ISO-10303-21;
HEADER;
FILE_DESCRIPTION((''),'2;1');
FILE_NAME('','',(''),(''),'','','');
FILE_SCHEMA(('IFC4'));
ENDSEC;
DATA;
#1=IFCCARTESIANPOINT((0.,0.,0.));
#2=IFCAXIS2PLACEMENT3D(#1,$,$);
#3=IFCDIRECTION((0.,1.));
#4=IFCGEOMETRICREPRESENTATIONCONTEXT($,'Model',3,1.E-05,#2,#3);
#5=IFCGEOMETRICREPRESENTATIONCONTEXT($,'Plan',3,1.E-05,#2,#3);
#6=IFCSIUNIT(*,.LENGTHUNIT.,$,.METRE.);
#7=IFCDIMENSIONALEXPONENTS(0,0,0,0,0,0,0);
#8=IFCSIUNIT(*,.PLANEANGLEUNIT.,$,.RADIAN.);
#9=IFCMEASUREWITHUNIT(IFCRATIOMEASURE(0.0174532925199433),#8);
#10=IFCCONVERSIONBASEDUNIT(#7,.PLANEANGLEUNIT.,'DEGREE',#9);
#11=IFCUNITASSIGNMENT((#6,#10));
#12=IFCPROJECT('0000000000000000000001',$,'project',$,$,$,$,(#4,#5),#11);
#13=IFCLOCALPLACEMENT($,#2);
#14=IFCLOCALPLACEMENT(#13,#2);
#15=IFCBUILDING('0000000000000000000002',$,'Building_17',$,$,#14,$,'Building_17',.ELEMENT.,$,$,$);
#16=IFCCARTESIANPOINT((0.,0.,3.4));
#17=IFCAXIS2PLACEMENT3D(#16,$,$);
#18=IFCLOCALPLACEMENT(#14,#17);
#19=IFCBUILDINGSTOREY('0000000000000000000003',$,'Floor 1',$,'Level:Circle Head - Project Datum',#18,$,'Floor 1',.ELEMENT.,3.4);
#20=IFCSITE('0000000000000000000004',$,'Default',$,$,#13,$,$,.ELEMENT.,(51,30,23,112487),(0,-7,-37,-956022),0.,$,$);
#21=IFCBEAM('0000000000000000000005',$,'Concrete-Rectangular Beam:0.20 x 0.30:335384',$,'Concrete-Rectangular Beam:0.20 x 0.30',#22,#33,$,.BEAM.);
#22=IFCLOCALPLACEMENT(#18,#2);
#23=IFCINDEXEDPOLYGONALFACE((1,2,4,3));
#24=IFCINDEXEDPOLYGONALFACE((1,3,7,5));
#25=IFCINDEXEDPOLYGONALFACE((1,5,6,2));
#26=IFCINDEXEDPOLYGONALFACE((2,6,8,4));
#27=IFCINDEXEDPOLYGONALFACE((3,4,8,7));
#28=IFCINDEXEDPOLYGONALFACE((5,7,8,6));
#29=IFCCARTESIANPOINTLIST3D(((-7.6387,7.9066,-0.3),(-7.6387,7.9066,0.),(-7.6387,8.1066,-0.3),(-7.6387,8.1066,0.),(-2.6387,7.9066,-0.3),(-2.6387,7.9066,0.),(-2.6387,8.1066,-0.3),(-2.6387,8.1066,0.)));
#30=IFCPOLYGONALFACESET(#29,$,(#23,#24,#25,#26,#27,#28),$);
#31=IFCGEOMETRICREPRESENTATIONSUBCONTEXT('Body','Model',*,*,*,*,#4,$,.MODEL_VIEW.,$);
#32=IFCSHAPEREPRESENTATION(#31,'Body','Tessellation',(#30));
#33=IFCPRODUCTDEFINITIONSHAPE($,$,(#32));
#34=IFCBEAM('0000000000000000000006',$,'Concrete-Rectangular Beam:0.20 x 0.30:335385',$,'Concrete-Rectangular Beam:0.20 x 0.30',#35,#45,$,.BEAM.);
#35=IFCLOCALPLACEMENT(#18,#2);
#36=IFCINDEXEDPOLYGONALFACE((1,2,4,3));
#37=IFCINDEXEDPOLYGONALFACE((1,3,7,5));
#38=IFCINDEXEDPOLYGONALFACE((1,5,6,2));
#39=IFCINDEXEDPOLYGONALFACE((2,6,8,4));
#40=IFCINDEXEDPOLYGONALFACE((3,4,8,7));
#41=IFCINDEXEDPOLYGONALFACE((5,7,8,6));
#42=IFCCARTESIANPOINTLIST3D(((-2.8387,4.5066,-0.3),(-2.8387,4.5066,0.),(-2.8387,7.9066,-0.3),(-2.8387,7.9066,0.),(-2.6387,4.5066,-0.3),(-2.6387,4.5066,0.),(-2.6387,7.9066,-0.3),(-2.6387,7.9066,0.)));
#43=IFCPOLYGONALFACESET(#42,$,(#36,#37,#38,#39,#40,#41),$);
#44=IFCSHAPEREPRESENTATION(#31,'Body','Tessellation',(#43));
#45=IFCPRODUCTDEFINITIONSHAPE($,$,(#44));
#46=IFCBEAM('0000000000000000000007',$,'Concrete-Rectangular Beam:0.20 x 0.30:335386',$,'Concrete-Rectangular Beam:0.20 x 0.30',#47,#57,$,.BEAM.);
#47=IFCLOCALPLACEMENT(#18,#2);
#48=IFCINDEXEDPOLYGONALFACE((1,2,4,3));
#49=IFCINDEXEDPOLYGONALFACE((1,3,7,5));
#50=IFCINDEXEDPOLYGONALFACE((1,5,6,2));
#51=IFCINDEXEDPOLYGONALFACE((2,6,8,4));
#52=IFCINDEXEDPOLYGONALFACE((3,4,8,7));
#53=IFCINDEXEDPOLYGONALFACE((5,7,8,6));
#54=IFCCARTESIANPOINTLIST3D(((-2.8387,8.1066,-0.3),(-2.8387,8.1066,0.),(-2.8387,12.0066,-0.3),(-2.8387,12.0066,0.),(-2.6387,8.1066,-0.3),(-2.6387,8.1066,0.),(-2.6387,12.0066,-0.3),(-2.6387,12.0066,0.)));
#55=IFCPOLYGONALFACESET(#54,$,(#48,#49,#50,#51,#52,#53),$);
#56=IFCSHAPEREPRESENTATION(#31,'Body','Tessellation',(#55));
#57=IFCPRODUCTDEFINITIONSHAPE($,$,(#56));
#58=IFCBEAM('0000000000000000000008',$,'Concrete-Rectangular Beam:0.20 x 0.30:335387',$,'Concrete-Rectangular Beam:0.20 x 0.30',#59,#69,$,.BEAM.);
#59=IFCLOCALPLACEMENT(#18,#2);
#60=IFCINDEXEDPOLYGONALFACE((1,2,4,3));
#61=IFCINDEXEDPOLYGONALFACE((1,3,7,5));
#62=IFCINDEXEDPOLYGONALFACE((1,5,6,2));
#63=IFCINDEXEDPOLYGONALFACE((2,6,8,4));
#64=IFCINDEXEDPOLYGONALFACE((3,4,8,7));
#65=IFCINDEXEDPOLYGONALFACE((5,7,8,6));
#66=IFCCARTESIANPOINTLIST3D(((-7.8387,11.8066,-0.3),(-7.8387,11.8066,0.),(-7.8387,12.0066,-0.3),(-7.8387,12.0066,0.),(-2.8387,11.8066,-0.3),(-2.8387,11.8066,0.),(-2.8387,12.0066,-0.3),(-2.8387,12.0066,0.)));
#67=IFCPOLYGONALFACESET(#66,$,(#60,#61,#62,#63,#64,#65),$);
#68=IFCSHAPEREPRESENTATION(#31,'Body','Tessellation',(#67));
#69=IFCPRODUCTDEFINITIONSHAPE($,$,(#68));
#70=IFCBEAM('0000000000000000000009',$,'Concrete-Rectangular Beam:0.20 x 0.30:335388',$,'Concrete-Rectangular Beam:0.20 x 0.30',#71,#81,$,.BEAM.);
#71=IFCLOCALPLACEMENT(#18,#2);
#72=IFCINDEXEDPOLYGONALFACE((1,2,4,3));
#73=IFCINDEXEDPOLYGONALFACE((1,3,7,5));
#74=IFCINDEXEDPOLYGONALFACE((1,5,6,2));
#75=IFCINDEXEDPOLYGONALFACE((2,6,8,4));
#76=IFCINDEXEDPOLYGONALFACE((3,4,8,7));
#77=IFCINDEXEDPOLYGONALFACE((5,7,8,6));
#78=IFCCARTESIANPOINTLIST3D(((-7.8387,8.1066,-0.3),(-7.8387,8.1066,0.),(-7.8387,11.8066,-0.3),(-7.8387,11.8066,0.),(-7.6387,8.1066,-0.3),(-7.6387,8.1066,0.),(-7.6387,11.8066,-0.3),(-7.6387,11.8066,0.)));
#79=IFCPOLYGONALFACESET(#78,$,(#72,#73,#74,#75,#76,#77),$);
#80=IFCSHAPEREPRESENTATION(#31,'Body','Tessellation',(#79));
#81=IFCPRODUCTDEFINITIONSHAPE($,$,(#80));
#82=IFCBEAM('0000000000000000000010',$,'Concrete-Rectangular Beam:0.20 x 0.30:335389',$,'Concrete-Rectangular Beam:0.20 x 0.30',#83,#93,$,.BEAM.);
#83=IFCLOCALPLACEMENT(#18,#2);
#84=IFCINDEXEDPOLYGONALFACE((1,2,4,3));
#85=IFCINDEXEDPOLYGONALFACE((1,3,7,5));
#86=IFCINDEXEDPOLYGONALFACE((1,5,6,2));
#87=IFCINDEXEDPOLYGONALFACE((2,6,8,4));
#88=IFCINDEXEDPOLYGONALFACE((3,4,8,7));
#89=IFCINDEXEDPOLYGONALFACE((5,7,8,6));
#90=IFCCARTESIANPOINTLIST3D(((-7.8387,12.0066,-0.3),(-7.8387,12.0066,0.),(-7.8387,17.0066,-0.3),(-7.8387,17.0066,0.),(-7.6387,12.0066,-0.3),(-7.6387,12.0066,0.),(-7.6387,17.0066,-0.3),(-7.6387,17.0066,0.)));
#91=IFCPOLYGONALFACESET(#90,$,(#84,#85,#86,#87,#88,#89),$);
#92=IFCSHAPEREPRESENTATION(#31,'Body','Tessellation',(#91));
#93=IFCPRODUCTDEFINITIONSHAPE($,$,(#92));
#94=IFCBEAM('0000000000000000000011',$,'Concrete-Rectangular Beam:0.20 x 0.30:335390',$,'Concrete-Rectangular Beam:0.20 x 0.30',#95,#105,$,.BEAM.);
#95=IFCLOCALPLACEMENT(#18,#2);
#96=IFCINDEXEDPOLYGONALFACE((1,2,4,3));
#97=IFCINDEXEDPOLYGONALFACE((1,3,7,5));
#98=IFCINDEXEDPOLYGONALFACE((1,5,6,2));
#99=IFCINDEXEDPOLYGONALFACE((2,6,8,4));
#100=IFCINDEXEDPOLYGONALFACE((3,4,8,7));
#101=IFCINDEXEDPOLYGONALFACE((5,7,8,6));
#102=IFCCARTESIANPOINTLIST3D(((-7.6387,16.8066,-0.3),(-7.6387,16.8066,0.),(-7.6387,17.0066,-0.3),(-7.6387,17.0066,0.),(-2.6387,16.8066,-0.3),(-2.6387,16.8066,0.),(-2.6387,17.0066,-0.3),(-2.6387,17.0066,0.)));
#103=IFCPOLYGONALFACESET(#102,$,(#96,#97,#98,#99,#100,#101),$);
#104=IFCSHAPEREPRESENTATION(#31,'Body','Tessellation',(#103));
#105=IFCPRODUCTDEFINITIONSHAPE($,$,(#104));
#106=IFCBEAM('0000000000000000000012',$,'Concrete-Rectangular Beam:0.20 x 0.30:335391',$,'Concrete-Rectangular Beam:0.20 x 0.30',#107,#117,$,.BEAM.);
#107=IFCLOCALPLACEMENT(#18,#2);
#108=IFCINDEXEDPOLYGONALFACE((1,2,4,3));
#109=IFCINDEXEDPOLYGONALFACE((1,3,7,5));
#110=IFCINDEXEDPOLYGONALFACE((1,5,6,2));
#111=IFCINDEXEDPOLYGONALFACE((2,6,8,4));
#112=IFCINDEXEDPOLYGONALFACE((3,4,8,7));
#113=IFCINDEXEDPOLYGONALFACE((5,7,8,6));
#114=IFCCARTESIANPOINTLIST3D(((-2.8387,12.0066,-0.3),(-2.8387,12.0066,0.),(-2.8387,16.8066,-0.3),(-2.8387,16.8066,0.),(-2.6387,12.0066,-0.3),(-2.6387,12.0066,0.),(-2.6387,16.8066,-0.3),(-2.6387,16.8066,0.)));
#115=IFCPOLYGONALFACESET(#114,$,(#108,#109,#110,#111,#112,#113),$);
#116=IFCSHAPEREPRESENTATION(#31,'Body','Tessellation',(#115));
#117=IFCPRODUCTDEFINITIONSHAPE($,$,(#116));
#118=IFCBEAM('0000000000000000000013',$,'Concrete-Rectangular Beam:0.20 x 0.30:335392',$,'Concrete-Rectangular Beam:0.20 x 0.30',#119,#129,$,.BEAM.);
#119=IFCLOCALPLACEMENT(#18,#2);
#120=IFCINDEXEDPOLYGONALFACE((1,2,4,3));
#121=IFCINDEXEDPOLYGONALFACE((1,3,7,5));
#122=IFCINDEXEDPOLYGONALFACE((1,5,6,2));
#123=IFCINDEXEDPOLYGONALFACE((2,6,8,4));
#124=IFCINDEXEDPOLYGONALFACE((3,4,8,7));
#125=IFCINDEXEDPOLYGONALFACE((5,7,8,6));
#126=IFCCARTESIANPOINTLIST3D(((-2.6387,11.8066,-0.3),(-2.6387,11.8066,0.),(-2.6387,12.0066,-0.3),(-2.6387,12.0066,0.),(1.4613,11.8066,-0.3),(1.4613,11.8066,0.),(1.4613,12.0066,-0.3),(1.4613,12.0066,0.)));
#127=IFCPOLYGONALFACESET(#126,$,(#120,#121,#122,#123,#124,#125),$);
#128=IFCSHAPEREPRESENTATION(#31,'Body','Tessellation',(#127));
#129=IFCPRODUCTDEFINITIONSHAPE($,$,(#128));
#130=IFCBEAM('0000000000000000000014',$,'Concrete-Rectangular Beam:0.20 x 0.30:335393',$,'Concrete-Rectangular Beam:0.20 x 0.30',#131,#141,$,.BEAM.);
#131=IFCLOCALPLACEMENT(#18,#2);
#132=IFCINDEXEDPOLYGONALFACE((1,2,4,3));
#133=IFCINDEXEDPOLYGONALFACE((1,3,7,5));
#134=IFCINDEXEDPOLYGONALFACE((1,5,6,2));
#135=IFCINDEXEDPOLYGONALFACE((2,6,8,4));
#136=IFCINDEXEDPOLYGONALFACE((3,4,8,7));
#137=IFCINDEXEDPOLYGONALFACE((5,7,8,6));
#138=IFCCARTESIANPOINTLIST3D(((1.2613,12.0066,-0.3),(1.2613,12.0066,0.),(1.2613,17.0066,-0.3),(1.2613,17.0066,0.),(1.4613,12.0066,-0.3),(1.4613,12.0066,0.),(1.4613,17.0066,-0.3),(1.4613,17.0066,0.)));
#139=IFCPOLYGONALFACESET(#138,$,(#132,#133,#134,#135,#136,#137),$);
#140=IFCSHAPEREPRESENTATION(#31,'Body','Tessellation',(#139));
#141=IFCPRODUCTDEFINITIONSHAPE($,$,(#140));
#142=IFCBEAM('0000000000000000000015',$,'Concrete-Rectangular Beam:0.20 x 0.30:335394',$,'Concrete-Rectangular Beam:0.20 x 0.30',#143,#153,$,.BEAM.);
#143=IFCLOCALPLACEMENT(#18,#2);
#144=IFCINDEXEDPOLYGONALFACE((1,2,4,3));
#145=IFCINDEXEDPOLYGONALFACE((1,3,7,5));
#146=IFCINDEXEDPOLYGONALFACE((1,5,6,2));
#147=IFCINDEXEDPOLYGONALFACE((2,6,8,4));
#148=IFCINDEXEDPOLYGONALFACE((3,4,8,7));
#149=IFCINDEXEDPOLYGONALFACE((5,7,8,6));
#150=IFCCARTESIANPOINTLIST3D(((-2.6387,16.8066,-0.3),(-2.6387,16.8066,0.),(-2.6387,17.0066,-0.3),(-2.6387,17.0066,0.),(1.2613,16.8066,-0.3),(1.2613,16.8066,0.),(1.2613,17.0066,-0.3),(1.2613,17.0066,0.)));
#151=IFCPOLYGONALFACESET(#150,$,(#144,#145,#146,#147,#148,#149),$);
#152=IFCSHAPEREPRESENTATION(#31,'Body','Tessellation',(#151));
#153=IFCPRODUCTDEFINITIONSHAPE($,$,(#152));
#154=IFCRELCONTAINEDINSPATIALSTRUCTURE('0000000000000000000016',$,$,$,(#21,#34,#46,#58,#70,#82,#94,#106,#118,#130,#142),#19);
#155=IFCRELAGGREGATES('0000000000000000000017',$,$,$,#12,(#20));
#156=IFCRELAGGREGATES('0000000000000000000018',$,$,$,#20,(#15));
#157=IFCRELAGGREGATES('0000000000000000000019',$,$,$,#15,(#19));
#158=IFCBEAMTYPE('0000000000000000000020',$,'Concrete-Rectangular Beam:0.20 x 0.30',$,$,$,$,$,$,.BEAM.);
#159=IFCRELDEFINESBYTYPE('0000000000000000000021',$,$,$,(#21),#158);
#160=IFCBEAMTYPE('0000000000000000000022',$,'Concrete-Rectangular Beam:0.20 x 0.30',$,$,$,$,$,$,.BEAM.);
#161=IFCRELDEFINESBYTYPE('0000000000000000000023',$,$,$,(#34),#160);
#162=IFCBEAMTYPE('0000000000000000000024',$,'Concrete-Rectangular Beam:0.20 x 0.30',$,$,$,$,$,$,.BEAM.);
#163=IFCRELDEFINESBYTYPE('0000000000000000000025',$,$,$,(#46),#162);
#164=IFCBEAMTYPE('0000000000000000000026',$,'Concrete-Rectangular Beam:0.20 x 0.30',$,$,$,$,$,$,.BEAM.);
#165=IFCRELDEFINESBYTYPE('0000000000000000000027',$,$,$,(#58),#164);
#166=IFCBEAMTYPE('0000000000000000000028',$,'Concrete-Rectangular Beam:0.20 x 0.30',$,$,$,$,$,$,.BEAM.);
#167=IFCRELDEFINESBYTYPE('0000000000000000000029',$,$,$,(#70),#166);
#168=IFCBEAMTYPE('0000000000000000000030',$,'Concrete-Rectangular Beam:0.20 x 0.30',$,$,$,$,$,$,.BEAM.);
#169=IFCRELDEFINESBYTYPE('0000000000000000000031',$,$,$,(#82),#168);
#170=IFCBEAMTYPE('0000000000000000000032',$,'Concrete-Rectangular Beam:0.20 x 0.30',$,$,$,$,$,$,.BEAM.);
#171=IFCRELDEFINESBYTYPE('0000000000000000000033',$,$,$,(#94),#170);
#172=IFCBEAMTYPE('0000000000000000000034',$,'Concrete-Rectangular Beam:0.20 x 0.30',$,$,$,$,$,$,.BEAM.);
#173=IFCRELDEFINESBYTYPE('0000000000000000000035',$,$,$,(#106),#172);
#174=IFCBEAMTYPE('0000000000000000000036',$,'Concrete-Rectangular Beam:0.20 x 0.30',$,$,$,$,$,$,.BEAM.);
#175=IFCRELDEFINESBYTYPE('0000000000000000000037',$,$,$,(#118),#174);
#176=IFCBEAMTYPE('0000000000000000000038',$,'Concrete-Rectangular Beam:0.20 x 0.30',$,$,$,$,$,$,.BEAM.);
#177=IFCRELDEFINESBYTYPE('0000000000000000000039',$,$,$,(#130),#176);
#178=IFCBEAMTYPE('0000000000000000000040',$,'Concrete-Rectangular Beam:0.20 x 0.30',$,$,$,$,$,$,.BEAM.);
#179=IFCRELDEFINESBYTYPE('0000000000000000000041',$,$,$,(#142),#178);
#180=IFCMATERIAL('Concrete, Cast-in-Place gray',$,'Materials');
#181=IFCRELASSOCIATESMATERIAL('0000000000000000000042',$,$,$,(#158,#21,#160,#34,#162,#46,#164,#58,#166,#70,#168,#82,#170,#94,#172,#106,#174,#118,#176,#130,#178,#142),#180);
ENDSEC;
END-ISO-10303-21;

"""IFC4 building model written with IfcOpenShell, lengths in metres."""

from ifc_helpers import new_model, entity, si_unit, converted_unit, direction, frame, origin, place, context, subcontext, project, spatial, indexed_curve, outline, extrude, source, transform, mapped, material, type_object, type_shapes, element, save


model = new_model("IFC4")

# Units and contexts
model_context = context("Model", 3, precision=1e-05, world=origin(), true_north=direction((0.0, 1.0)))
plan_context = context("Plan", 3, precision=1e-05, world=origin(), true_north=direction((0.0, 1.0)))
body_context = subcontext(model_context, "Body", "Model", "MODEL_VIEW")
ifc_project = project(units=[si_unit("LENGTHUNIT", "METRE"), converted_unit("PLANEANGLEUNIT", "DEGREE", entity("IfcRatioMeasure", 0.0174532925199433), si_unit("PLANEANGLEUNIT", "RADIAN"), dimensions=[0, 0, 0, 0, 0, 0, 0])], contexts=[model_context, plan_context])

# Site, building, storey
site_placement = place(None, origin())
site = spatial("IfcSite", under=ifc_project, at=site_placement, Name="Default", CompositionType="ELEMENT", RefLatitude=(51, 30, 23, 112487), RefLongitude=(0, -7, -37, -956022), RefElevation=0.0)
building_placement = place(site_placement, origin())
building = spatial("IfcBuilding", under=site, at=building_placement, Name="Building_17", LongName="Building_17", CompositionType="ELEMENT")
storey_placement = place(building_placement, frame((0.0, 0.0, 3.4)))
storey = spatial("IfcBuildingStorey", under=building, at=storey_placement, Name="Floor 1", ObjectType="Level:Circle Head - Project Datum", LongName="Floor 1", CompositionType="ELEMENT", Elevation=3.4)

# Beams
ifc_material_1 = material(Name="Concrete, Cast-in-Place gray", Category="Materials")
beam_type_1 = type_object("IfcBeamType", Name="Concrete-Rectangular Beam:0.20 x 0.30", PredefinedType="BEAM", material=ifc_material_1)
shared_shape_1 = source(origin(), body_context, "Body", "SweptSolid", [
    extrude(outline(indexed_curve([(-0.15, -0.1), (0.15, -0.1), (0.15, 0.1), (-0.15, 0.1), (-0.15, -0.1)], self_intersect=False)), frame((-7.6387, 8.0066, 3.25), z_axis=(1.0, 0.0, 0.0), x_axis=(0.0, 0.0, -1.0)), (0.0, 0.0, 1.0), 5.0),
])
type_shapes(beam_type_1, [shared_shape_1])
beam_1_placement = place(storey_placement, frame((0.0, 0.0, -3.4)))
element("IfcBeam", 1, at=beam_1_placement, inside=storey, type_object=beam_type_1, material=ifc_material_1, Name="Concrete-Rectangular Beam:0.20 x 0.30:335384", ObjectType="Concrete-Rectangular Beam:0.20 x 0.30", PredefinedType="BEAM", context=body_context, shape_type="MappedRepresentation", body=[
    mapped(shared_shape_1, transform((0.0, 0.0, 0.0), scale=1.0)),
])
beam_type_2 = type_object("IfcBeamType", Name="Concrete-Rectangular Beam:0.20 x 0.30", PredefinedType="BEAM", material=ifc_material_1)
shared_shape_2 = source(origin(), body_context, "Body", "SweptSolid", [
    extrude(outline(indexed_curve([(-0.1, -0.15), (0.1, -0.15), (0.1, 0.15), (-0.1, 0.15), (-0.1, -0.15)], self_intersect=False)), frame((-2.7387, 7.9066, 3.25), z_axis=(0.0, -1.0, 0.0), x_axis=(-1.0, 0.0, 0.0)), (0.0, 0.0, 1.0), 3.4),
])
type_shapes(beam_type_2, [shared_shape_2])
beam_2_placement = place(storey_placement, frame((0.0, 0.0, -3.4)))
element("IfcBeam", 2, at=beam_2_placement, inside=storey, type_object=beam_type_2, material=ifc_material_1, Name="Concrete-Rectangular Beam:0.20 x 0.30:335385", ObjectType="Concrete-Rectangular Beam:0.20 x 0.30", PredefinedType="BEAM", context=body_context, shape_type="MappedRepresentation", body=[
    mapped(shared_shape_2, transform((0.0, 0.0, 0.0), scale=1.0)),
])
beam_type_3 = type_object("IfcBeamType", Name="Concrete-Rectangular Beam:0.20 x 0.30", PredefinedType="BEAM", material=ifc_material_1)
shared_shape_3 = source(origin(), body_context, "Body", "SweptSolid", [
    extrude(outline(indexed_curve([(-0.1, -0.15), (0.1, -0.15), (0.1, 0.15), (-0.1, 0.15), (-0.1, -0.15)], self_intersect=False)), frame((-2.7387, 8.1066, 3.25), z_axis=(0.0, 1.0, 0.0), x_axis=(-1.0, 0.0, 0.0)), (0.0, 0.0, 1.0), 3.9),
])
type_shapes(beam_type_3, [shared_shape_3])
beam_3_placement = place(storey_placement, frame((0.0, 0.0, -3.4)))
element("IfcBeam", 3, at=beam_3_placement, inside=storey, type_object=beam_type_3, material=ifc_material_1, Name="Concrete-Rectangular Beam:0.20 x 0.30:335386", ObjectType="Concrete-Rectangular Beam:0.20 x 0.30", PredefinedType="BEAM", context=body_context, shape_type="MappedRepresentation", body=[
    mapped(shared_shape_3, transform((0.0, 0.0, 0.0), scale=1.0)),
])
beam_type_4 = type_object("IfcBeamType", Name="Concrete-Rectangular Beam:0.20 x 0.30", PredefinedType="BEAM", material=ifc_material_1)
shared_shape_4 = source(origin(), body_context, "Body", "SweptSolid", [
    extrude(outline(indexed_curve([(-0.15, -0.1), (0.15, -0.1), (0.15, 0.1), (-0.15, 0.1), (-0.15, -0.1)], self_intersect=False)), frame((-2.8387, 11.9066, 3.25), z_axis=(-1.0, 0.0, 0.0), x_axis=(0.0, 0.0, -1.0)), (0.0, 0.0, 1.0), 5.0),
])
type_shapes(beam_type_4, [shared_shape_4])
beam_4_placement = place(storey_placement, frame((0.0, 0.0, -3.4)))
element("IfcBeam", 4, at=beam_4_placement, inside=storey, type_object=beam_type_4, material=ifc_material_1, Name="Concrete-Rectangular Beam:0.20 x 0.30:335387", ObjectType="Concrete-Rectangular Beam:0.20 x 0.30", PredefinedType="BEAM", context=body_context, shape_type="MappedRepresentation", body=[
    mapped(shared_shape_4, transform((0.0, 0.0, 0.0), scale=1.0)),
])
beam_type_5 = type_object("IfcBeamType", Name="Concrete-Rectangular Beam:0.20 x 0.30", PredefinedType="BEAM", material=ifc_material_1)
shared_shape_5 = source(origin(), body_context, "Body", "SweptSolid", [
    extrude(outline(indexed_curve([(-0.1, -0.15), (0.1, -0.15), (0.1, 0.15), (-0.1, 0.15), (-0.1, -0.15)], self_intersect=False)), frame((-7.7387, 11.8066, 3.25), z_axis=(0.0, -1.0, 0.0), x_axis=(-1.0, 0.0, 0.0)), (0.0, 0.0, 1.0), 3.7),
])
type_shapes(beam_type_5, [shared_shape_5])
beam_5_placement = place(storey_placement, frame((0.0, 0.0, -3.4)))
element("IfcBeam", 5, at=beam_5_placement, inside=storey, type_object=beam_type_5, material=ifc_material_1, Name="Concrete-Rectangular Beam:0.20 x 0.30:335388", ObjectType="Concrete-Rectangular Beam:0.20 x 0.30", PredefinedType="BEAM", context=body_context, shape_type="MappedRepresentation", body=[
    mapped(shared_shape_5, transform((0.0, 0.0, 0.0), scale=1.0)),
])
beam_type_6 = type_object("IfcBeamType", Name="Concrete-Rectangular Beam:0.20 x 0.30", PredefinedType="BEAM", material=ifc_material_1)
shared_shape_6 = source(origin(), body_context, "Body", "SweptSolid", [
    extrude(outline(indexed_curve([(-0.1, -0.15), (0.1, -0.15), (0.1, 0.15), (-0.1, 0.15), (-0.1, -0.15)], self_intersect=False)), frame((-7.7387, 17.0066, 3.25), z_axis=(0.0, -1.0, 0.0), x_axis=(-1.0, 0.0, 0.0)), (0.0, 0.0, 1.0), 5.0),
])
type_shapes(beam_type_6, [shared_shape_6])
beam_6_placement = place(storey_placement, frame((0.0, 0.0, -3.4)))
element("IfcBeam", 6, at=beam_6_placement, inside=storey, type_object=beam_type_6, material=ifc_material_1, Name="Concrete-Rectangular Beam:0.20 x 0.30:335389", ObjectType="Concrete-Rectangular Beam:0.20 x 0.30", PredefinedType="BEAM", context=body_context, shape_type="MappedRepresentation", body=[
    mapped(shared_shape_6, transform((0.0, 0.0, 0.0), scale=1.0)),
])
beam_type_7 = type_object("IfcBeamType", Name="Concrete-Rectangular Beam:0.20 x 0.30", PredefinedType="BEAM", material=ifc_material_1)
shared_shape_7 = source(origin(), body_context, "Body", "SweptSolid", [
    extrude(outline(indexed_curve([(-0.15, -0.1), (0.15, -0.1), (0.15, 0.1), (-0.15, 0.1), (-0.15, -0.1)], self_intersect=False)), frame((-7.6387, 16.9066, 3.25), z_axis=(1.0, 0.0, 0.0), x_axis=(0.0, 0.0, -1.0)), (0.0, 0.0, 1.0), 5.0),
])
type_shapes(beam_type_7, [shared_shape_7])
beam_7_placement = place(storey_placement, frame((0.0, 0.0, -3.4)))
element("IfcBeam", 7, at=beam_7_placement, inside=storey, type_object=beam_type_7, material=ifc_material_1, Name="Concrete-Rectangular Beam:0.20 x 0.30:335390", ObjectType="Concrete-Rectangular Beam:0.20 x 0.30", PredefinedType="BEAM", context=body_context, shape_type="MappedRepresentation", body=[
    mapped(shared_shape_7, transform((0.0, 0.0, 0.0), scale=1.0)),
])
beam_type_8 = type_object("IfcBeamType", Name="Concrete-Rectangular Beam:0.20 x 0.30", PredefinedType="BEAM", material=ifc_material_1)
shared_shape_8 = source(origin(), body_context, "Body", "SweptSolid", [
    extrude(outline(indexed_curve([(-0.1, -0.15), (0.1, -0.15), (0.1, 0.15), (-0.1, 0.15), (-0.1, -0.15)], self_intersect=False)), frame((-2.7387, 16.8066, 3.25), z_axis=(0.0, -1.0, 0.0), x_axis=(-1.0, 0.0, 0.0)), (0.0, 0.0, 1.0), 4.8),
])
type_shapes(beam_type_8, [shared_shape_8])
beam_8_placement = place(storey_placement, frame((0.0, 0.0, -3.4)))
element("IfcBeam", 8, at=beam_8_placement, inside=storey, type_object=beam_type_8, material=ifc_material_1, Name="Concrete-Rectangular Beam:0.20 x 0.30:335391", ObjectType="Concrete-Rectangular Beam:0.20 x 0.30", PredefinedType="BEAM", context=body_context, shape_type="MappedRepresentation", body=[
    mapped(shared_shape_8, transform((0.0, 0.0, 0.0), scale=1.0)),
])
beam_type_9 = type_object("IfcBeamType", Name="Concrete-Rectangular Beam:0.20 x 0.30", PredefinedType="BEAM", material=ifc_material_1)
shared_shape_9 = source(origin(), body_context, "Body", "SweptSolid", [
    extrude(outline(indexed_curve([(-0.15, -0.1), (0.15, -0.1), (0.15, 0.1), (-0.15, 0.1), (-0.15, -0.1)], self_intersect=False)), frame((-2.6387, 11.9066, 3.25), z_axis=(1.0, 0.0, 0.0), x_axis=(0.0, 0.0, -1.0)), (0.0, 0.0, 1.0), 4.1),
])
type_shapes(beam_type_9, [shared_shape_9])
beam_9_placement = place(storey_placement, frame((0.0, 0.0, -3.4)))
element("IfcBeam", 9, at=beam_9_placement, inside=storey, type_object=beam_type_9, material=ifc_material_1, Name="Concrete-Rectangular Beam:0.20 x 0.30:335392", ObjectType="Concrete-Rectangular Beam:0.20 x 0.30", PredefinedType="BEAM", context=body_context, shape_type="MappedRepresentation", body=[
    mapped(shared_shape_9, transform((0.0, 0.0, 0.0), scale=1.0)),
])
beam_type_10 = type_object("IfcBeamType", Name="Concrete-Rectangular Beam:0.20 x 0.30", PredefinedType="BEAM", material=ifc_material_1)
shared_shape_10 = source(origin(), body_context, "Body", "SweptSolid", [
    extrude(outline(indexed_curve([(-0.1, -0.15), (0.1, -0.15), (0.1, 0.15), (-0.1, 0.15), (-0.1, -0.15)], self_intersect=False)), frame((1.3613, 12.0066, 3.25), z_axis=(0.0, 1.0, 0.0), x_axis=(-1.0, 0.0, 0.0)), (0.0, 0.0, 1.0), 5.0),
])
type_shapes(beam_type_10, [shared_shape_10])
beam_10_placement = place(storey_placement, frame((0.0, 0.0, -3.4)))
element("IfcBeam", 10, at=beam_10_placement, inside=storey, type_object=beam_type_10, material=ifc_material_1, Name="Concrete-Rectangular Beam:0.20 x 0.30:335393", ObjectType="Concrete-Rectangular Beam:0.20 x 0.30", PredefinedType="BEAM", context=body_context, shape_type="MappedRepresentation", body=[
    mapped(shared_shape_10, transform((0.0, 0.0, 0.0), scale=1.0)),
])
beam_type_11 = type_object("IfcBeamType", Name="Concrete-Rectangular Beam:0.20 x 0.30", PredefinedType="BEAM", material=ifc_material_1)
shared_shape_11 = source(origin(), body_context, "Body", "SweptSolid", [
    extrude(outline(indexed_curve([(-0.15, -0.1), (0.15, -0.1), (0.15, 0.1), (-0.15, 0.1), (-0.15, -0.1)], self_intersect=False)), frame((1.2613, 16.9066, 3.25), z_axis=(-1.0, 0.0, 0.0), x_axis=(0.0, 0.0, -1.0)), (0.0, 0.0, 1.0), 3.9),
])
type_shapes(beam_type_11, [shared_shape_11])
beam_11_placement = place(storey_placement, frame((0.0, 0.0, -3.4)))
element("IfcBeam", 11, at=beam_11_placement, inside=storey, type_object=beam_type_11, material=ifc_material_1, Name="Concrete-Rectangular Beam:0.20 x 0.30:335394", ObjectType="Concrete-Rectangular Beam:0.20 x 0.30", PredefinedType="BEAM", context=body_context, shape_type="MappedRepresentation", body=[
    mapped(shared_shape_11, transform((0.0, 0.0, 0.0), scale=1.0)),
])

save(model, "model.ifc")
